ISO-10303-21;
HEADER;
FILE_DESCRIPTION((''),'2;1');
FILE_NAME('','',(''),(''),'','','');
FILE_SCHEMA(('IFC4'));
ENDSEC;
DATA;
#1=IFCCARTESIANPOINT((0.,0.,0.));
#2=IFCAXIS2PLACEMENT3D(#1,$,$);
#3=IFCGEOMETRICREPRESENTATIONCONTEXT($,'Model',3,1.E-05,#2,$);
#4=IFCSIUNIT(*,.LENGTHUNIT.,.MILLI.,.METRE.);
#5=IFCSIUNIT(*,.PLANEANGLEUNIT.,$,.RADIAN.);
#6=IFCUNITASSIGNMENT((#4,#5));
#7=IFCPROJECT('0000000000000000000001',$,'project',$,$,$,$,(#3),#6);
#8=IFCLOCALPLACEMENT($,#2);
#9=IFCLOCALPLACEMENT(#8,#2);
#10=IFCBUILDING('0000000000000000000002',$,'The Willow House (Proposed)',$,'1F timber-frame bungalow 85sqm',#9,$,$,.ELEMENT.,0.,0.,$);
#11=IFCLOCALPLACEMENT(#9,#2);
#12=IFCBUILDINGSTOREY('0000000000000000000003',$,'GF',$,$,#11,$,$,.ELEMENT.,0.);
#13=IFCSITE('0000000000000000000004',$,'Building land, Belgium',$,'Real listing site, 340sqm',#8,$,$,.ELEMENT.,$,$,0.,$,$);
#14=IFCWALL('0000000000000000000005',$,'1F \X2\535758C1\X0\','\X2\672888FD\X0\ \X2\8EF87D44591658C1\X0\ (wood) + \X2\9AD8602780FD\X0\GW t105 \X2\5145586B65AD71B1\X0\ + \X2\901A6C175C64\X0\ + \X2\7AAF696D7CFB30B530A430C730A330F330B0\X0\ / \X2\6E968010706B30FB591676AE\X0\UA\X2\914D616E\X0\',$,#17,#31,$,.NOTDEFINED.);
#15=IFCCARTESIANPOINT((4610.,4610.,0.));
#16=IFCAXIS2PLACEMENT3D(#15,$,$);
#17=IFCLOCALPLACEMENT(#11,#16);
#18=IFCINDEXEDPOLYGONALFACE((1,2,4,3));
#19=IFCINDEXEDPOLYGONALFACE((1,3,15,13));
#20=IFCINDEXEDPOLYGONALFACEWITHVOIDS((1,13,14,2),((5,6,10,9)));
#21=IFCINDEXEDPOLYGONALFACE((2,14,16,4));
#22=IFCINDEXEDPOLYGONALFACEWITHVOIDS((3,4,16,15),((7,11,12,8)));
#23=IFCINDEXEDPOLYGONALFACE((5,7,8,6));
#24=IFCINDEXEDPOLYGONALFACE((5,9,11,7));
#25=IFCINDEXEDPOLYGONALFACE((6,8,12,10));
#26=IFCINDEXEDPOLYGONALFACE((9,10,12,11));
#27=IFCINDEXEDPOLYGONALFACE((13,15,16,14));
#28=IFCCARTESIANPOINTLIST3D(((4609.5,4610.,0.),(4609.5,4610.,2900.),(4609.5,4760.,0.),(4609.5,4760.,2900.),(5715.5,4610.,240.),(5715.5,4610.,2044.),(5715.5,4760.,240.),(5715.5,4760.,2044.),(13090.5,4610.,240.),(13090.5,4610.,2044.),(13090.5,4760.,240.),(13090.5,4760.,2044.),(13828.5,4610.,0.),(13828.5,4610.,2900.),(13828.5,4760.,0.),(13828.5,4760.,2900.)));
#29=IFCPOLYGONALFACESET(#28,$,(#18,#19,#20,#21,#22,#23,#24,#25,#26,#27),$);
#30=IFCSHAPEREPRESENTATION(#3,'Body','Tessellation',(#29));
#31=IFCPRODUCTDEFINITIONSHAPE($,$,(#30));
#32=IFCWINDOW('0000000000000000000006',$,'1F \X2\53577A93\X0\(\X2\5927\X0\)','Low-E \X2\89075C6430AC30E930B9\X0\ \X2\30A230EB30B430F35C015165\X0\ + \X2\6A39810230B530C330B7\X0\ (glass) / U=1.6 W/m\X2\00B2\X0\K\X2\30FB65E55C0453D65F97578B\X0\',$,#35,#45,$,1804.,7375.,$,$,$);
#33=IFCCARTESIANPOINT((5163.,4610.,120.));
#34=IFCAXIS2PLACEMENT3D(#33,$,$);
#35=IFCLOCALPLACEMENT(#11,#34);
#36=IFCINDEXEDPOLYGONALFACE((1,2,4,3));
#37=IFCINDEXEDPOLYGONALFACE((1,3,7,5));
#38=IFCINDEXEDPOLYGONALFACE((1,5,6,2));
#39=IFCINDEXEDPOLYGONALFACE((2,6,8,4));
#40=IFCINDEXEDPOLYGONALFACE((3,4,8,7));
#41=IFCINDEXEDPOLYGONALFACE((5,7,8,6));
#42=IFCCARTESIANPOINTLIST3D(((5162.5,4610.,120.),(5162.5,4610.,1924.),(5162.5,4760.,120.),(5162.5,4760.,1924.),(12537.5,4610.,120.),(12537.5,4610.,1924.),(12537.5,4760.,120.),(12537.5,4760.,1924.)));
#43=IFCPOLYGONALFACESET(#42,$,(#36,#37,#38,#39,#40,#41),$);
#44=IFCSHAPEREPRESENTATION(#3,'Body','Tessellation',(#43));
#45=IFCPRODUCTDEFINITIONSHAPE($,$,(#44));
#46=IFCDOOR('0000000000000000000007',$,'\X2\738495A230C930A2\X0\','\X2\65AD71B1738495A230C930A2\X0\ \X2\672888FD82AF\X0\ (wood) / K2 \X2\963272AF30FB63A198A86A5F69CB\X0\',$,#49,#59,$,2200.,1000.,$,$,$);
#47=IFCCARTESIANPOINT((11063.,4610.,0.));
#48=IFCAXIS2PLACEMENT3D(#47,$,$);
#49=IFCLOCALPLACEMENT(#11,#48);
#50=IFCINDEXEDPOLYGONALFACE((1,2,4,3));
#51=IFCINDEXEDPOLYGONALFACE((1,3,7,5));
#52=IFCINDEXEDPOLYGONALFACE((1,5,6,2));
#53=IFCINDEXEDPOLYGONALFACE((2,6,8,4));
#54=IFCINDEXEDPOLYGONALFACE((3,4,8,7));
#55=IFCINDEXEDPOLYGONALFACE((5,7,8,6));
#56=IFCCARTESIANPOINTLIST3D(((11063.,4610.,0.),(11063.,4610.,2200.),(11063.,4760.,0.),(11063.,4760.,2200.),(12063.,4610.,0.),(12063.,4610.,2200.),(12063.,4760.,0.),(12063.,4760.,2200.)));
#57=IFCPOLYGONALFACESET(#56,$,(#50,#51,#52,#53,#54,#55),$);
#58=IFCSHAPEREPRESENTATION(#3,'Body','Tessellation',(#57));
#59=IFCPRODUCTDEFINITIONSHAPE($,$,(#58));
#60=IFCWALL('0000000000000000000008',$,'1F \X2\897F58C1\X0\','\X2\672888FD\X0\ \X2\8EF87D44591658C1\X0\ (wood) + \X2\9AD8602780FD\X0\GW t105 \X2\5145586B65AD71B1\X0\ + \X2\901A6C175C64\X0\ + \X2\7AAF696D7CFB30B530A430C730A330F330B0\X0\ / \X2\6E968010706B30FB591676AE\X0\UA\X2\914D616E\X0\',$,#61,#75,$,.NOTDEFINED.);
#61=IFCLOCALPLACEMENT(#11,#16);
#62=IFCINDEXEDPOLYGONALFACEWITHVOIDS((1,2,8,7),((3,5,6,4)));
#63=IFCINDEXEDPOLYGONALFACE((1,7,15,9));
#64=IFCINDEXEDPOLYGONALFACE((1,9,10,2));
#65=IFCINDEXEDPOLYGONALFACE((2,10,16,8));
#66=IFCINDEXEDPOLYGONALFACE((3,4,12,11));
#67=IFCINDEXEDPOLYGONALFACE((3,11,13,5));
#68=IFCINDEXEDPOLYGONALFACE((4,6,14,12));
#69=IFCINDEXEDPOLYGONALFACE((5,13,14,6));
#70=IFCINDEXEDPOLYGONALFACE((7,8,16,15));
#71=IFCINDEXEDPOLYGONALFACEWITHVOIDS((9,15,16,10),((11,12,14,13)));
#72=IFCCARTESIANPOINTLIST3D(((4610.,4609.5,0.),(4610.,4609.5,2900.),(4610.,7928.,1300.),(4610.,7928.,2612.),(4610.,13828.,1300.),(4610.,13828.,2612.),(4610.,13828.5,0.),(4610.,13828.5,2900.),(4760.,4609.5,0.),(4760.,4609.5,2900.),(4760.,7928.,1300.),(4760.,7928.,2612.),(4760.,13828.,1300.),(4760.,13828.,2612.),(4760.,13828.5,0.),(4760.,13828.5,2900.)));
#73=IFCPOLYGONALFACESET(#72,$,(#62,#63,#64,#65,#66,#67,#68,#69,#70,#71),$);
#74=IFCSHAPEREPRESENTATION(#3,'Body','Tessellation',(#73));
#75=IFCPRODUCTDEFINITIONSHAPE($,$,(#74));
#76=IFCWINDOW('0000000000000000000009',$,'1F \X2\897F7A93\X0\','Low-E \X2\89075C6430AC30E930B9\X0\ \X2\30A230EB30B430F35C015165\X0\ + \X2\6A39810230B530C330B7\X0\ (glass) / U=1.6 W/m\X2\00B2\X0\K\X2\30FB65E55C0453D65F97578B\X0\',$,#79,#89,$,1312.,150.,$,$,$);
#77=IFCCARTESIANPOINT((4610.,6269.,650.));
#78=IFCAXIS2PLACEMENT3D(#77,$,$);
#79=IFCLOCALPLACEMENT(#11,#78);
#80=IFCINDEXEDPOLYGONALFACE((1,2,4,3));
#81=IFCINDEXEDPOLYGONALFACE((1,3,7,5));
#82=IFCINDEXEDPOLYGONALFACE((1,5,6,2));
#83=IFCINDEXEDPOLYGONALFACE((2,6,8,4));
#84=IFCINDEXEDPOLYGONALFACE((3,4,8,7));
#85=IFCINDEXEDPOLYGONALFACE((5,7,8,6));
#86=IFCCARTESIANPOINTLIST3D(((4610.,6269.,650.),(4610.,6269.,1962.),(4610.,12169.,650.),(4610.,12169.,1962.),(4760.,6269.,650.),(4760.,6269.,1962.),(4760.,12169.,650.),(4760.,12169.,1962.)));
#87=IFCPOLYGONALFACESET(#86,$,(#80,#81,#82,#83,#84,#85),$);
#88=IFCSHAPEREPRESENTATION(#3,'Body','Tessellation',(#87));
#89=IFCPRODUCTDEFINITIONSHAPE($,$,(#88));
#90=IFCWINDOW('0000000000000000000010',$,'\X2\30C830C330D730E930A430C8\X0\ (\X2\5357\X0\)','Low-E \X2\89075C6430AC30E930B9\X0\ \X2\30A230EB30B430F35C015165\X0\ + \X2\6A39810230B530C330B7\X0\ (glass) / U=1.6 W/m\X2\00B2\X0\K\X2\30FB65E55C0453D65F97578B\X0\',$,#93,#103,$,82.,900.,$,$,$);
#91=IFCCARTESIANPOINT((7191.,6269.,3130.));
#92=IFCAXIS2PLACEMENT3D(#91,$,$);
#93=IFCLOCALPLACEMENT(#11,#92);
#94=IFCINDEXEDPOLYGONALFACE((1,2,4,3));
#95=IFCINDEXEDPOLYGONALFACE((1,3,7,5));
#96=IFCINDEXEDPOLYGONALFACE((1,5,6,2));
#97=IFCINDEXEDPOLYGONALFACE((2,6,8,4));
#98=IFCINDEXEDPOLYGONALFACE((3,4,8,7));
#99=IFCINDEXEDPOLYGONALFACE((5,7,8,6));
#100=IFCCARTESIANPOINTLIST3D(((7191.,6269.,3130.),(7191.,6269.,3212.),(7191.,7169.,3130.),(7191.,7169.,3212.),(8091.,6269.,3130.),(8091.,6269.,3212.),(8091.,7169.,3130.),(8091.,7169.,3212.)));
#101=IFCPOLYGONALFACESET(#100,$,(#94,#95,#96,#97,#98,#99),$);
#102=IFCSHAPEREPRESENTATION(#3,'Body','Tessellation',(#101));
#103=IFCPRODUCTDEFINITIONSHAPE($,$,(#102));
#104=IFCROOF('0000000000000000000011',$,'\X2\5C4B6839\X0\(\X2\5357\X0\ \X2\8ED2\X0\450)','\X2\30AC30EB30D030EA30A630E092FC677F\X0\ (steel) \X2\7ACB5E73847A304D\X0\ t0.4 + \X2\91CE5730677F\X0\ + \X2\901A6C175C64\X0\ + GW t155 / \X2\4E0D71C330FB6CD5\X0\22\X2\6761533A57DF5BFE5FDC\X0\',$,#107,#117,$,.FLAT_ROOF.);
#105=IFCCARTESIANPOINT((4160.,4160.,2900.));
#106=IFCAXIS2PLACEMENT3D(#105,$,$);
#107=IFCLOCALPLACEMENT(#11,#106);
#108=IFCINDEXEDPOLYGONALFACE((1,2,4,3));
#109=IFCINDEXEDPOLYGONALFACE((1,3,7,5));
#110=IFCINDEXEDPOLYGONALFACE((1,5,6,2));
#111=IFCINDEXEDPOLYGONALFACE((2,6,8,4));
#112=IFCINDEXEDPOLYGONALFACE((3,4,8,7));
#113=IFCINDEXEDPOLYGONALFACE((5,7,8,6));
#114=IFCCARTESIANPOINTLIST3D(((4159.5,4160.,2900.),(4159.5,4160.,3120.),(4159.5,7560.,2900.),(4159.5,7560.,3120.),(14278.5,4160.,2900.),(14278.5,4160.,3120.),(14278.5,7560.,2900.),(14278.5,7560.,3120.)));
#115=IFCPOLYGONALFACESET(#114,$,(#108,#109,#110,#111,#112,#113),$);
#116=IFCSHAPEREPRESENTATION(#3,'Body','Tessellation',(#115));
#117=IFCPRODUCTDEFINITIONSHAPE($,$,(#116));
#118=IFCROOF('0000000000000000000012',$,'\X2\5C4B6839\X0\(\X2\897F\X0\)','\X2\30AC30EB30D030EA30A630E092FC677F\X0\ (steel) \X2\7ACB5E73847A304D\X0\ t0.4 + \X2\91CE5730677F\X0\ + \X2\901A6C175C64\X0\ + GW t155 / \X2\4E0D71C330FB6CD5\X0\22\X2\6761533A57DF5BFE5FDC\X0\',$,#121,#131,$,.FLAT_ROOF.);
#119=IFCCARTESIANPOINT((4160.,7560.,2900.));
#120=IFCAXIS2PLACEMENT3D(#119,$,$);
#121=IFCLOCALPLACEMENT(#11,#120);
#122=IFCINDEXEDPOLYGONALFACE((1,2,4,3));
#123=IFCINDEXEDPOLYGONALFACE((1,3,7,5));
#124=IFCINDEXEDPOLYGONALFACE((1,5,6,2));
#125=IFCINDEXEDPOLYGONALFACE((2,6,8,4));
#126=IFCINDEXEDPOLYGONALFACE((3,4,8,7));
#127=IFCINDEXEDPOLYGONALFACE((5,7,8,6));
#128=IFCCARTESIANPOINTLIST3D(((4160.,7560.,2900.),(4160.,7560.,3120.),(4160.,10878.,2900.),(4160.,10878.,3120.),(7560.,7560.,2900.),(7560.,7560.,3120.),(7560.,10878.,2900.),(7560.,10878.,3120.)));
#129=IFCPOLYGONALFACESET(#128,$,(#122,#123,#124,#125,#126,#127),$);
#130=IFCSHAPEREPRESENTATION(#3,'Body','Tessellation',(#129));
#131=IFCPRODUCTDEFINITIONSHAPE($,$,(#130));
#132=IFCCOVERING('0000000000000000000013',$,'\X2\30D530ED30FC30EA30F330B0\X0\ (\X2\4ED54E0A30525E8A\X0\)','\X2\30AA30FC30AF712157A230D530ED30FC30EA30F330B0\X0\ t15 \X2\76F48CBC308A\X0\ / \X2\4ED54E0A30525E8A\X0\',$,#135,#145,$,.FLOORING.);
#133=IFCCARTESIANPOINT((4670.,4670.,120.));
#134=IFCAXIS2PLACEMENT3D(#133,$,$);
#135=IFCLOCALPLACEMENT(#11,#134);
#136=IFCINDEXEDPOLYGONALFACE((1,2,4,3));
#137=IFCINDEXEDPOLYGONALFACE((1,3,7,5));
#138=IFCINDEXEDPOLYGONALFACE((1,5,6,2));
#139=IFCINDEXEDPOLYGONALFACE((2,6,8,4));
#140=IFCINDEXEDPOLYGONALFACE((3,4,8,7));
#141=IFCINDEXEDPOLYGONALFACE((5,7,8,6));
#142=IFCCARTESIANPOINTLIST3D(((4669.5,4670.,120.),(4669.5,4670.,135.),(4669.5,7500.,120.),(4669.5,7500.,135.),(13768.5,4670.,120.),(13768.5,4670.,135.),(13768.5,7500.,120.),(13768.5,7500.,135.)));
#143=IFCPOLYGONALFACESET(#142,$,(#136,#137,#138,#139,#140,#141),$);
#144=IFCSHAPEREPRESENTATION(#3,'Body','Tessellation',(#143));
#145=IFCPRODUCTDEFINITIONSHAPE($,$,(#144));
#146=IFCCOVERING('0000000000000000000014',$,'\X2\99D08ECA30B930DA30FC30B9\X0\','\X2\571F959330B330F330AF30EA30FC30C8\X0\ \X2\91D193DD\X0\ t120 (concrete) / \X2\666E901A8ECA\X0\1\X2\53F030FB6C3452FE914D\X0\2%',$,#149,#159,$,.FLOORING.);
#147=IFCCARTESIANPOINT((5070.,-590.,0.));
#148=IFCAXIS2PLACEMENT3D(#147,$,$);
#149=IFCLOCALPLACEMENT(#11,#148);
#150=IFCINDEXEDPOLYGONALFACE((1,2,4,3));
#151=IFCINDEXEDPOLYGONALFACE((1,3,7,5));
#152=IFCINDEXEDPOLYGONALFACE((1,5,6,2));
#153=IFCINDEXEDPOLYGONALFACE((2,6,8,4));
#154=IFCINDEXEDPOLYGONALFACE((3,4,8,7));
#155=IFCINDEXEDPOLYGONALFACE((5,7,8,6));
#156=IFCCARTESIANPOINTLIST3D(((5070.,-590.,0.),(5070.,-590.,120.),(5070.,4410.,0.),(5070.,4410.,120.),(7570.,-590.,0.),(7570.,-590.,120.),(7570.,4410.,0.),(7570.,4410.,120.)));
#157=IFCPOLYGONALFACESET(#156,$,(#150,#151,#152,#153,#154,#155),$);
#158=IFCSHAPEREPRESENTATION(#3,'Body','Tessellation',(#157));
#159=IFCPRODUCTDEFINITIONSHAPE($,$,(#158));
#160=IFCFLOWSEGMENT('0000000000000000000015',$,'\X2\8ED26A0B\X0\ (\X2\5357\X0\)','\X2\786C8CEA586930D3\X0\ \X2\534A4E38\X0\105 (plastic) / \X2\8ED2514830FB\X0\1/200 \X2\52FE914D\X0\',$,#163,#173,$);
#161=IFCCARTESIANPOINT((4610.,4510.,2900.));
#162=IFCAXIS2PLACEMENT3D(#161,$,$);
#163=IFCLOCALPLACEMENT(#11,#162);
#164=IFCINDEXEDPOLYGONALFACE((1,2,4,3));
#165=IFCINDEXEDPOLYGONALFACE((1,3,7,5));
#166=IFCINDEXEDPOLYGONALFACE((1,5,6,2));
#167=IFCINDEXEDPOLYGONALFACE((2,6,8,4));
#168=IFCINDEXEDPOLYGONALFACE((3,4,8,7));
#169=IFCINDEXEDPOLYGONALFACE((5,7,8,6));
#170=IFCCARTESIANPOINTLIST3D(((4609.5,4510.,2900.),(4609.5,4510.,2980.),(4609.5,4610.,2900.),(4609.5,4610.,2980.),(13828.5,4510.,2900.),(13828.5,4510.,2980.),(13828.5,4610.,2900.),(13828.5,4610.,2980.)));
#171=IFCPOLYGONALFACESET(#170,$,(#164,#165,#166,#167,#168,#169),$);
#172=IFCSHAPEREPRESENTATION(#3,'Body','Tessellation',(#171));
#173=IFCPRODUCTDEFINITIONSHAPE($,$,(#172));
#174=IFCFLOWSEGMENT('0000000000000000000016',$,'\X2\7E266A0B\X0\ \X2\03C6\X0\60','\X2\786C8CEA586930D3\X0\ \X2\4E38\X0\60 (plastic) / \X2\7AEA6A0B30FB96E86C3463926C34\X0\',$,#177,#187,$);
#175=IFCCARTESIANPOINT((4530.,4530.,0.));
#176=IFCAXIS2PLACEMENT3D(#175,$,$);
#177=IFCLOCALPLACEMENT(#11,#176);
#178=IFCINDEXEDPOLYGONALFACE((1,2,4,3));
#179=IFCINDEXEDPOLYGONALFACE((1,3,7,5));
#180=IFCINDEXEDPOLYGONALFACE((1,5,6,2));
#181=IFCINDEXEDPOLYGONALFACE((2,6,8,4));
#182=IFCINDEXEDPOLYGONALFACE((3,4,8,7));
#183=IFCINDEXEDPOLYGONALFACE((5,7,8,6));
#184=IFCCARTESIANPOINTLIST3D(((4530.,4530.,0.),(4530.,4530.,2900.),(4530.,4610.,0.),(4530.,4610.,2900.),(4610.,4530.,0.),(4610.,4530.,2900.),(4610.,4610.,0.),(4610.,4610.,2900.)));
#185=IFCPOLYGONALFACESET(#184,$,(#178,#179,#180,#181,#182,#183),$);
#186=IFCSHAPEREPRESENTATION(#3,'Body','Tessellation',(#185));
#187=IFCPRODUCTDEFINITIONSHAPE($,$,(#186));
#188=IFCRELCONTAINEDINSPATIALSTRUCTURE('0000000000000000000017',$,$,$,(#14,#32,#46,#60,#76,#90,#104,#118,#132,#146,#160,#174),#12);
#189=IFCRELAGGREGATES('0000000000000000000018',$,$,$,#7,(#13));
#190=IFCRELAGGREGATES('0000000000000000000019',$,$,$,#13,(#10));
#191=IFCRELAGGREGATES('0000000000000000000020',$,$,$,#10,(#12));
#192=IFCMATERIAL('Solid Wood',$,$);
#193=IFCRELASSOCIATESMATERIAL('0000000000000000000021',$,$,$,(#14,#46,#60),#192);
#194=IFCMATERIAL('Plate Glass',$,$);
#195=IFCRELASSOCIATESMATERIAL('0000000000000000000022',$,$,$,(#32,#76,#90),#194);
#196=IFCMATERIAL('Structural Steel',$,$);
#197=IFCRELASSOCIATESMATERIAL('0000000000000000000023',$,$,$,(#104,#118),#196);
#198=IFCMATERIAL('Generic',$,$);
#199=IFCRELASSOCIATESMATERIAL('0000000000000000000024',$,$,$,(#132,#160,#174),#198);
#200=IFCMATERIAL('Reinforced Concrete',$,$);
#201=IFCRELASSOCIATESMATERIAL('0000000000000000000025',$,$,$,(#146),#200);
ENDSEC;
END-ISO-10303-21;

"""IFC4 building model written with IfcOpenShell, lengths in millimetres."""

from ifc_helpers import new_model, si_unit, frame, frame_2d, origin, place, context, project, spatial, rectangle, extrude, material, element, fill, save


model = new_model("IFC4")

# Units and contexts
model_context = context("Model", 3, precision=1e-05, world=origin())
ifc_project = project(units=[si_unit("LENGTHUNIT", "METRE", prefix="MILLI"), si_unit("PLANEANGLEUNIT", "RADIAN")], contexts=[model_context])

# Site, building, storey
site_placement = place(None, origin())
site = spatial("IfcSite", under=ifc_project, at=site_placement, Name="Building land, Belgium", ObjectType="Real listing site, 340sqm", CompositionType="ELEMENT", RefElevation=0.0)
building_placement = place(site_placement, origin())
building = spatial("IfcBuilding", under=site, at=building_placement, Name="The Willow House (Proposed)", ObjectType="1F timber-frame bungalow 85sqm", CompositionType="ELEMENT", ElevationOfRefHeight=0.0, ElevationOfTerrain=0.0)
storey_placement = place(building_placement, origin())
storey = spatial("IfcBuildingStorey", under=building, at=storey_placement, Name="GF", CompositionType="ELEMENT", Elevation=0.0)

# Shared definitions
ifc_material_1 = material(Name="Solid Wood")

# Shared definitions
ifc_material_2 = material(Name="Reinforced Concrete")

# Wall, openings, window, door
wall_1_placement = place(storey_placement, frame((4610.0, 4610.0, 0.0)))
wall_1 = element("IfcWall", 1, at=wall_1_placement, inside=storey, material=ifc_material_1, Name="1F 南壁", Description="木製 軸組外壁 (wood) + 高性能GW t105 充填断熱 + 通気層 + 窯業系サイディング / 準耐火・外皮UA配慮", PredefinedType="NOTDEFINED", context=model_context, shape_type="SweptSolid", body=[
    extrude(rectangle(XDim=9219.0, YDim=150.0, at=frame_2d((4609.0, 75.0))), frame((4610.0, 4610.0, 0.0)), (0.0, 0.0, 1.0), 2900.0),
])
opening_1_placement = place(storey_placement, frame((5163.0, 4610.0, 120.0)))
opening_1 = element("IfcOpeningElement", 2, at=opening_1_placement, cuts=wall_1, PredefinedType="NOTDEFINED", context=model_context, shape_type="SweptSolid", body=[
    extrude(rectangle(XDim=7375.0, YDim=150.0, at=frame_2d((3687.0, 75.0))), frame((5163.0, 4610.0, 120.0)), (0.0, 0.0, 1.0), 1804.0),
])
opening_2_placement = place(storey_placement, frame((11063.0, 4610.0, 0.0)))
opening_2 = element("IfcOpeningElement", 3, at=opening_2_placement, cuts=wall_1, PredefinedType="NOTDEFINED", context=model_context, shape_type="SweptSolid", body=[
    extrude(rectangle(XDim=1000.0, YDim=150.0, at=frame_2d((500.0, 75.0))), frame((11063.0, 4610.0, 0.0)), (0.0, 0.0, 1.0), 2200.0),
])
ifc_material_3 = material(Name="Plate Glass")
window_1_placement = place(storey_placement, frame((5163.0, 4610.0, 120.0)))
window_1 = element("IfcWindow", 4, at=window_1_placement, inside=storey, material=ifc_material_3, Name="1F 南窓(大)", Description="Low-E 複層ガラス アルゴン封入 + 樹脂サッシ (glass) / U=1.6 W/m²K・日射取得型", OverallHeight=1804.0, OverallWidth=7375.0, context=model_context, shape_type="SweptSolid", body=[
    extrude(rectangle(XDim=7375.0, YDim=150.0, at=frame_2d((3687.0, 75.0))), frame((5163.0, 4610.0, 120.0)), (0.0, 0.0, 1.0), 1804.0),
])
fill(opening_1, window_1)
door_placement = place(storey_placement, frame((11063.0, 4610.0, 0.0)))
door = element("IfcDoor", 5, at=door_placement, inside=storey, material=ifc_material_1, Name="玄関ドア", Description="断熱玄関ドア 木製芯 (wood) / K2 防犯・採風機構", OverallHeight=2200.0, OverallWidth=1000.0, context=model_context, shape_type="SweptSolid", body=[
    extrude(rectangle(XDim=1000.0, YDim=150.0, at=frame_2d((500.0, 75.0))), frame((11063.0, 4610.0, 0.0)), (0.0, 0.0, 1.0), 2200.0),
])
fill(opening_2, door)

# Wall, opening, window
wall_2_placement = place(storey_placement, frame((4610.0, 4610.0, 0.0)))
wall_2 = element("IfcWall", 6, at=wall_2_placement, inside=storey, material=ifc_material_1, Name="1F 西壁", Description="木製 軸組外壁 (wood) + 高性能GW t105 充填断熱 + 通気層 + 窯業系サイディング / 準耐火・外皮UA配慮", PredefinedType="NOTDEFINED", context=model_context, shape_type="SweptSolid", body=[
    extrude(rectangle(XDim=150.0, YDim=9219.0, at=frame_2d((75.0, 4609.0))), frame((4610.0, 4610.0, 0.0)), (0.0, 0.0, 1.0), 2900.0),
])
opening_3_placement = place(storey_placement, frame((4610.0, 6269.0, 650.0)))
opening_3 = element("IfcOpeningElement", 7, at=opening_3_placement, cuts=wall_2, PredefinedType="NOTDEFINED", context=model_context, shape_type="SweptSolid", body=[
    extrude(rectangle(XDim=150.0, YDim=5900.0, at=frame_2d((75.0, 2950.0))), frame((4610.0, 6269.0, 650.0)), (0.0, 0.0, 1.0), 1312.0),
])
window_2_placement = place(storey_placement, frame((4610.0, 6269.0, 650.0)))
window_2 = element("IfcWindow", 8, at=window_2_placement, inside=storey, material=ifc_material_3, Name="1F 西窓", Description="Low-E 複層ガラス アルゴン封入 + 樹脂サッシ (glass) / U=1.6 W/m²K・日射取得型", OverallHeight=1312.0, OverallWidth=150.0, context=model_context, shape_type="SweptSolid", body=[
    extrude(rectangle(XDim=150.0, YDim=5900.0, at=frame_2d((75.0, 2950.0))), frame((4610.0, 6269.0, 650.0)), (0.0, 0.0, 1.0), 1312.0),
])
fill(opening_3, window_2)

# Window
window_3_placement = place(storey_placement, frame((7191.0, 6269.0, 3130.0)))
element("IfcWindow", 9, at=window_3_placement, inside=storey, material=ifc_material_3, Name="トップライト (南)", Description="Low-E 複層ガラス アルゴン封入 + 樹脂サッシ (glass) / U=1.6 W/m²K・日射取得型", OverallHeight=82.0, OverallWidth=900.0, context=model_context, shape_type="SweptSolid", body=[
    extrude(rectangle(XDim=900.0, YDim=900.0, at=frame_2d((450.0, 450.0))), frame((7191.0, 6269.0, 3130.0)), (0.0, 0.0, 1.0), 82.0),
])

# Roofs
ifc_material_4 = material(Name="Structural Steel")
roof_1_placement = place(storey_placement, frame((4160.0, 4160.0, 2900.0)))
element("IfcRoof", 10, at=roof_1_placement, inside=storey, material=ifc_material_4, Name="屋根(南 軒450)", Description="ガルバリウム鋼板 (steel) 立平葺き t0.4 + 野地板 + 通気層 + GW t155 / 不燃・法22条区域対応", PredefinedType="FLAT_ROOF", context=model_context, shape_type="SweptSolid", body=[
    extrude(rectangle(XDim=10119.0, YDim=3400.0, at=frame_2d((5059.0, 1700.0))), frame((4160.0, 4160.0, 2900.0)), (0.0, 0.0, 1.0), 220.0),
])
roof_2_placement = place(storey_placement, frame((4160.0, 7560.0, 2900.0)))
element("IfcRoof", 11, at=roof_2_placement, inside=storey, material=ifc_material_4, Name="屋根(西)", Description="ガルバリウム鋼板 (steel) 立平葺き t0.4 + 野地板 + 通気層 + GW t155 / 不燃・法22条区域対応", PredefinedType="FLAT_ROOF", context=model_context, shape_type="SweptSolid", body=[
    extrude(rectangle(XDim=3400.0, YDim=3318.0, at=frame_2d((1700.0, 1659.0))), frame((4160.0, 7560.0, 2900.0)), (0.0, 0.0, 1.0), 220.0),
])

# Coverings
ifc_material_5 = material(Name="Generic")
covering_1_placement = place(storey_placement, frame((4670.0, 4670.0, 120.0)))
element("IfcCovering", 12, at=covering_1_placement, inside=storey, material=ifc_material_5, Name="フローリング (仕上げ床)", Description="オーク無垢フローリング t15 直貼り / 仕上げ床", PredefinedType="FLOORING", context=model_context, shape_type="SweptSolid", body=[
    extrude(rectangle(XDim=9099.0, YDim=2830.0, at=frame_2d((4549.0, 1415.0))), frame((4670.0, 4670.0, 120.0)), (0.0, 0.0, 1.0), 15.0),
])
covering_2_placement = place(storey_placement, frame((5070.0, -590.0, 0.0)))
element("IfcCovering", 13, at=covering_2_placement, inside=storey, material=ifc_material_2, Name="駐車スペース", Description="土間コンクリート 金鏝 t120 (concrete) / 普通車1台・水勾配2%", PredefinedType="FLOORING", context=model_context, shape_type="SweptSolid", body=[
    extrude(rectangle(XDim=2500.0, YDim=5000.0, at=frame_2d((1250.0, 2500.0))), frame((5070.0, -590.0, 0.0)), (0.0, 0.0, 1.0), 120.0),
])

# Flow segments
flow_segment_1_placement = place(storey_placement, frame((4610.0, 4510.0, 2900.0)))
element("IfcFlowSegment", 14, at=flow_segment_1_placement, inside=storey, material=ifc_material_5, Name="軒樋 (南)", Description="硬質塩ビ 半丸105 (plastic) / 軒先・1/200 勾配", context=model_context, shape_type="SweptSolid", body=[
    extrude(rectangle(XDim=9219.0, YDim=100.0, at=frame_2d((4609.0, 50.0))), frame((4610.0, 4510.0, 2900.0)), (0.0, 0.0, 1.0), 80.0),
])
flow_segment_2_placement = place(storey_placement, frame((4530.0, 4530.0, 0.0)))
element("IfcFlowSegment", 15, at=flow_segment_2_placement, inside=storey, material=ifc_material_5, Name="縦樋 φ60", Description="硬質塩ビ 丸60 (plastic) / 竪樋・雨水排水", context=model_context, shape_type="SweptSolid", body=[
    extrude(rectangle(XDim=80.0, YDim=80.0, at=frame_2d((40.0, 40.0))), frame((4530.0, 4530.0, 0.0)), (0.0, 0.0, 1.0), 2900.0),
])

save(model, "model.ifc")
